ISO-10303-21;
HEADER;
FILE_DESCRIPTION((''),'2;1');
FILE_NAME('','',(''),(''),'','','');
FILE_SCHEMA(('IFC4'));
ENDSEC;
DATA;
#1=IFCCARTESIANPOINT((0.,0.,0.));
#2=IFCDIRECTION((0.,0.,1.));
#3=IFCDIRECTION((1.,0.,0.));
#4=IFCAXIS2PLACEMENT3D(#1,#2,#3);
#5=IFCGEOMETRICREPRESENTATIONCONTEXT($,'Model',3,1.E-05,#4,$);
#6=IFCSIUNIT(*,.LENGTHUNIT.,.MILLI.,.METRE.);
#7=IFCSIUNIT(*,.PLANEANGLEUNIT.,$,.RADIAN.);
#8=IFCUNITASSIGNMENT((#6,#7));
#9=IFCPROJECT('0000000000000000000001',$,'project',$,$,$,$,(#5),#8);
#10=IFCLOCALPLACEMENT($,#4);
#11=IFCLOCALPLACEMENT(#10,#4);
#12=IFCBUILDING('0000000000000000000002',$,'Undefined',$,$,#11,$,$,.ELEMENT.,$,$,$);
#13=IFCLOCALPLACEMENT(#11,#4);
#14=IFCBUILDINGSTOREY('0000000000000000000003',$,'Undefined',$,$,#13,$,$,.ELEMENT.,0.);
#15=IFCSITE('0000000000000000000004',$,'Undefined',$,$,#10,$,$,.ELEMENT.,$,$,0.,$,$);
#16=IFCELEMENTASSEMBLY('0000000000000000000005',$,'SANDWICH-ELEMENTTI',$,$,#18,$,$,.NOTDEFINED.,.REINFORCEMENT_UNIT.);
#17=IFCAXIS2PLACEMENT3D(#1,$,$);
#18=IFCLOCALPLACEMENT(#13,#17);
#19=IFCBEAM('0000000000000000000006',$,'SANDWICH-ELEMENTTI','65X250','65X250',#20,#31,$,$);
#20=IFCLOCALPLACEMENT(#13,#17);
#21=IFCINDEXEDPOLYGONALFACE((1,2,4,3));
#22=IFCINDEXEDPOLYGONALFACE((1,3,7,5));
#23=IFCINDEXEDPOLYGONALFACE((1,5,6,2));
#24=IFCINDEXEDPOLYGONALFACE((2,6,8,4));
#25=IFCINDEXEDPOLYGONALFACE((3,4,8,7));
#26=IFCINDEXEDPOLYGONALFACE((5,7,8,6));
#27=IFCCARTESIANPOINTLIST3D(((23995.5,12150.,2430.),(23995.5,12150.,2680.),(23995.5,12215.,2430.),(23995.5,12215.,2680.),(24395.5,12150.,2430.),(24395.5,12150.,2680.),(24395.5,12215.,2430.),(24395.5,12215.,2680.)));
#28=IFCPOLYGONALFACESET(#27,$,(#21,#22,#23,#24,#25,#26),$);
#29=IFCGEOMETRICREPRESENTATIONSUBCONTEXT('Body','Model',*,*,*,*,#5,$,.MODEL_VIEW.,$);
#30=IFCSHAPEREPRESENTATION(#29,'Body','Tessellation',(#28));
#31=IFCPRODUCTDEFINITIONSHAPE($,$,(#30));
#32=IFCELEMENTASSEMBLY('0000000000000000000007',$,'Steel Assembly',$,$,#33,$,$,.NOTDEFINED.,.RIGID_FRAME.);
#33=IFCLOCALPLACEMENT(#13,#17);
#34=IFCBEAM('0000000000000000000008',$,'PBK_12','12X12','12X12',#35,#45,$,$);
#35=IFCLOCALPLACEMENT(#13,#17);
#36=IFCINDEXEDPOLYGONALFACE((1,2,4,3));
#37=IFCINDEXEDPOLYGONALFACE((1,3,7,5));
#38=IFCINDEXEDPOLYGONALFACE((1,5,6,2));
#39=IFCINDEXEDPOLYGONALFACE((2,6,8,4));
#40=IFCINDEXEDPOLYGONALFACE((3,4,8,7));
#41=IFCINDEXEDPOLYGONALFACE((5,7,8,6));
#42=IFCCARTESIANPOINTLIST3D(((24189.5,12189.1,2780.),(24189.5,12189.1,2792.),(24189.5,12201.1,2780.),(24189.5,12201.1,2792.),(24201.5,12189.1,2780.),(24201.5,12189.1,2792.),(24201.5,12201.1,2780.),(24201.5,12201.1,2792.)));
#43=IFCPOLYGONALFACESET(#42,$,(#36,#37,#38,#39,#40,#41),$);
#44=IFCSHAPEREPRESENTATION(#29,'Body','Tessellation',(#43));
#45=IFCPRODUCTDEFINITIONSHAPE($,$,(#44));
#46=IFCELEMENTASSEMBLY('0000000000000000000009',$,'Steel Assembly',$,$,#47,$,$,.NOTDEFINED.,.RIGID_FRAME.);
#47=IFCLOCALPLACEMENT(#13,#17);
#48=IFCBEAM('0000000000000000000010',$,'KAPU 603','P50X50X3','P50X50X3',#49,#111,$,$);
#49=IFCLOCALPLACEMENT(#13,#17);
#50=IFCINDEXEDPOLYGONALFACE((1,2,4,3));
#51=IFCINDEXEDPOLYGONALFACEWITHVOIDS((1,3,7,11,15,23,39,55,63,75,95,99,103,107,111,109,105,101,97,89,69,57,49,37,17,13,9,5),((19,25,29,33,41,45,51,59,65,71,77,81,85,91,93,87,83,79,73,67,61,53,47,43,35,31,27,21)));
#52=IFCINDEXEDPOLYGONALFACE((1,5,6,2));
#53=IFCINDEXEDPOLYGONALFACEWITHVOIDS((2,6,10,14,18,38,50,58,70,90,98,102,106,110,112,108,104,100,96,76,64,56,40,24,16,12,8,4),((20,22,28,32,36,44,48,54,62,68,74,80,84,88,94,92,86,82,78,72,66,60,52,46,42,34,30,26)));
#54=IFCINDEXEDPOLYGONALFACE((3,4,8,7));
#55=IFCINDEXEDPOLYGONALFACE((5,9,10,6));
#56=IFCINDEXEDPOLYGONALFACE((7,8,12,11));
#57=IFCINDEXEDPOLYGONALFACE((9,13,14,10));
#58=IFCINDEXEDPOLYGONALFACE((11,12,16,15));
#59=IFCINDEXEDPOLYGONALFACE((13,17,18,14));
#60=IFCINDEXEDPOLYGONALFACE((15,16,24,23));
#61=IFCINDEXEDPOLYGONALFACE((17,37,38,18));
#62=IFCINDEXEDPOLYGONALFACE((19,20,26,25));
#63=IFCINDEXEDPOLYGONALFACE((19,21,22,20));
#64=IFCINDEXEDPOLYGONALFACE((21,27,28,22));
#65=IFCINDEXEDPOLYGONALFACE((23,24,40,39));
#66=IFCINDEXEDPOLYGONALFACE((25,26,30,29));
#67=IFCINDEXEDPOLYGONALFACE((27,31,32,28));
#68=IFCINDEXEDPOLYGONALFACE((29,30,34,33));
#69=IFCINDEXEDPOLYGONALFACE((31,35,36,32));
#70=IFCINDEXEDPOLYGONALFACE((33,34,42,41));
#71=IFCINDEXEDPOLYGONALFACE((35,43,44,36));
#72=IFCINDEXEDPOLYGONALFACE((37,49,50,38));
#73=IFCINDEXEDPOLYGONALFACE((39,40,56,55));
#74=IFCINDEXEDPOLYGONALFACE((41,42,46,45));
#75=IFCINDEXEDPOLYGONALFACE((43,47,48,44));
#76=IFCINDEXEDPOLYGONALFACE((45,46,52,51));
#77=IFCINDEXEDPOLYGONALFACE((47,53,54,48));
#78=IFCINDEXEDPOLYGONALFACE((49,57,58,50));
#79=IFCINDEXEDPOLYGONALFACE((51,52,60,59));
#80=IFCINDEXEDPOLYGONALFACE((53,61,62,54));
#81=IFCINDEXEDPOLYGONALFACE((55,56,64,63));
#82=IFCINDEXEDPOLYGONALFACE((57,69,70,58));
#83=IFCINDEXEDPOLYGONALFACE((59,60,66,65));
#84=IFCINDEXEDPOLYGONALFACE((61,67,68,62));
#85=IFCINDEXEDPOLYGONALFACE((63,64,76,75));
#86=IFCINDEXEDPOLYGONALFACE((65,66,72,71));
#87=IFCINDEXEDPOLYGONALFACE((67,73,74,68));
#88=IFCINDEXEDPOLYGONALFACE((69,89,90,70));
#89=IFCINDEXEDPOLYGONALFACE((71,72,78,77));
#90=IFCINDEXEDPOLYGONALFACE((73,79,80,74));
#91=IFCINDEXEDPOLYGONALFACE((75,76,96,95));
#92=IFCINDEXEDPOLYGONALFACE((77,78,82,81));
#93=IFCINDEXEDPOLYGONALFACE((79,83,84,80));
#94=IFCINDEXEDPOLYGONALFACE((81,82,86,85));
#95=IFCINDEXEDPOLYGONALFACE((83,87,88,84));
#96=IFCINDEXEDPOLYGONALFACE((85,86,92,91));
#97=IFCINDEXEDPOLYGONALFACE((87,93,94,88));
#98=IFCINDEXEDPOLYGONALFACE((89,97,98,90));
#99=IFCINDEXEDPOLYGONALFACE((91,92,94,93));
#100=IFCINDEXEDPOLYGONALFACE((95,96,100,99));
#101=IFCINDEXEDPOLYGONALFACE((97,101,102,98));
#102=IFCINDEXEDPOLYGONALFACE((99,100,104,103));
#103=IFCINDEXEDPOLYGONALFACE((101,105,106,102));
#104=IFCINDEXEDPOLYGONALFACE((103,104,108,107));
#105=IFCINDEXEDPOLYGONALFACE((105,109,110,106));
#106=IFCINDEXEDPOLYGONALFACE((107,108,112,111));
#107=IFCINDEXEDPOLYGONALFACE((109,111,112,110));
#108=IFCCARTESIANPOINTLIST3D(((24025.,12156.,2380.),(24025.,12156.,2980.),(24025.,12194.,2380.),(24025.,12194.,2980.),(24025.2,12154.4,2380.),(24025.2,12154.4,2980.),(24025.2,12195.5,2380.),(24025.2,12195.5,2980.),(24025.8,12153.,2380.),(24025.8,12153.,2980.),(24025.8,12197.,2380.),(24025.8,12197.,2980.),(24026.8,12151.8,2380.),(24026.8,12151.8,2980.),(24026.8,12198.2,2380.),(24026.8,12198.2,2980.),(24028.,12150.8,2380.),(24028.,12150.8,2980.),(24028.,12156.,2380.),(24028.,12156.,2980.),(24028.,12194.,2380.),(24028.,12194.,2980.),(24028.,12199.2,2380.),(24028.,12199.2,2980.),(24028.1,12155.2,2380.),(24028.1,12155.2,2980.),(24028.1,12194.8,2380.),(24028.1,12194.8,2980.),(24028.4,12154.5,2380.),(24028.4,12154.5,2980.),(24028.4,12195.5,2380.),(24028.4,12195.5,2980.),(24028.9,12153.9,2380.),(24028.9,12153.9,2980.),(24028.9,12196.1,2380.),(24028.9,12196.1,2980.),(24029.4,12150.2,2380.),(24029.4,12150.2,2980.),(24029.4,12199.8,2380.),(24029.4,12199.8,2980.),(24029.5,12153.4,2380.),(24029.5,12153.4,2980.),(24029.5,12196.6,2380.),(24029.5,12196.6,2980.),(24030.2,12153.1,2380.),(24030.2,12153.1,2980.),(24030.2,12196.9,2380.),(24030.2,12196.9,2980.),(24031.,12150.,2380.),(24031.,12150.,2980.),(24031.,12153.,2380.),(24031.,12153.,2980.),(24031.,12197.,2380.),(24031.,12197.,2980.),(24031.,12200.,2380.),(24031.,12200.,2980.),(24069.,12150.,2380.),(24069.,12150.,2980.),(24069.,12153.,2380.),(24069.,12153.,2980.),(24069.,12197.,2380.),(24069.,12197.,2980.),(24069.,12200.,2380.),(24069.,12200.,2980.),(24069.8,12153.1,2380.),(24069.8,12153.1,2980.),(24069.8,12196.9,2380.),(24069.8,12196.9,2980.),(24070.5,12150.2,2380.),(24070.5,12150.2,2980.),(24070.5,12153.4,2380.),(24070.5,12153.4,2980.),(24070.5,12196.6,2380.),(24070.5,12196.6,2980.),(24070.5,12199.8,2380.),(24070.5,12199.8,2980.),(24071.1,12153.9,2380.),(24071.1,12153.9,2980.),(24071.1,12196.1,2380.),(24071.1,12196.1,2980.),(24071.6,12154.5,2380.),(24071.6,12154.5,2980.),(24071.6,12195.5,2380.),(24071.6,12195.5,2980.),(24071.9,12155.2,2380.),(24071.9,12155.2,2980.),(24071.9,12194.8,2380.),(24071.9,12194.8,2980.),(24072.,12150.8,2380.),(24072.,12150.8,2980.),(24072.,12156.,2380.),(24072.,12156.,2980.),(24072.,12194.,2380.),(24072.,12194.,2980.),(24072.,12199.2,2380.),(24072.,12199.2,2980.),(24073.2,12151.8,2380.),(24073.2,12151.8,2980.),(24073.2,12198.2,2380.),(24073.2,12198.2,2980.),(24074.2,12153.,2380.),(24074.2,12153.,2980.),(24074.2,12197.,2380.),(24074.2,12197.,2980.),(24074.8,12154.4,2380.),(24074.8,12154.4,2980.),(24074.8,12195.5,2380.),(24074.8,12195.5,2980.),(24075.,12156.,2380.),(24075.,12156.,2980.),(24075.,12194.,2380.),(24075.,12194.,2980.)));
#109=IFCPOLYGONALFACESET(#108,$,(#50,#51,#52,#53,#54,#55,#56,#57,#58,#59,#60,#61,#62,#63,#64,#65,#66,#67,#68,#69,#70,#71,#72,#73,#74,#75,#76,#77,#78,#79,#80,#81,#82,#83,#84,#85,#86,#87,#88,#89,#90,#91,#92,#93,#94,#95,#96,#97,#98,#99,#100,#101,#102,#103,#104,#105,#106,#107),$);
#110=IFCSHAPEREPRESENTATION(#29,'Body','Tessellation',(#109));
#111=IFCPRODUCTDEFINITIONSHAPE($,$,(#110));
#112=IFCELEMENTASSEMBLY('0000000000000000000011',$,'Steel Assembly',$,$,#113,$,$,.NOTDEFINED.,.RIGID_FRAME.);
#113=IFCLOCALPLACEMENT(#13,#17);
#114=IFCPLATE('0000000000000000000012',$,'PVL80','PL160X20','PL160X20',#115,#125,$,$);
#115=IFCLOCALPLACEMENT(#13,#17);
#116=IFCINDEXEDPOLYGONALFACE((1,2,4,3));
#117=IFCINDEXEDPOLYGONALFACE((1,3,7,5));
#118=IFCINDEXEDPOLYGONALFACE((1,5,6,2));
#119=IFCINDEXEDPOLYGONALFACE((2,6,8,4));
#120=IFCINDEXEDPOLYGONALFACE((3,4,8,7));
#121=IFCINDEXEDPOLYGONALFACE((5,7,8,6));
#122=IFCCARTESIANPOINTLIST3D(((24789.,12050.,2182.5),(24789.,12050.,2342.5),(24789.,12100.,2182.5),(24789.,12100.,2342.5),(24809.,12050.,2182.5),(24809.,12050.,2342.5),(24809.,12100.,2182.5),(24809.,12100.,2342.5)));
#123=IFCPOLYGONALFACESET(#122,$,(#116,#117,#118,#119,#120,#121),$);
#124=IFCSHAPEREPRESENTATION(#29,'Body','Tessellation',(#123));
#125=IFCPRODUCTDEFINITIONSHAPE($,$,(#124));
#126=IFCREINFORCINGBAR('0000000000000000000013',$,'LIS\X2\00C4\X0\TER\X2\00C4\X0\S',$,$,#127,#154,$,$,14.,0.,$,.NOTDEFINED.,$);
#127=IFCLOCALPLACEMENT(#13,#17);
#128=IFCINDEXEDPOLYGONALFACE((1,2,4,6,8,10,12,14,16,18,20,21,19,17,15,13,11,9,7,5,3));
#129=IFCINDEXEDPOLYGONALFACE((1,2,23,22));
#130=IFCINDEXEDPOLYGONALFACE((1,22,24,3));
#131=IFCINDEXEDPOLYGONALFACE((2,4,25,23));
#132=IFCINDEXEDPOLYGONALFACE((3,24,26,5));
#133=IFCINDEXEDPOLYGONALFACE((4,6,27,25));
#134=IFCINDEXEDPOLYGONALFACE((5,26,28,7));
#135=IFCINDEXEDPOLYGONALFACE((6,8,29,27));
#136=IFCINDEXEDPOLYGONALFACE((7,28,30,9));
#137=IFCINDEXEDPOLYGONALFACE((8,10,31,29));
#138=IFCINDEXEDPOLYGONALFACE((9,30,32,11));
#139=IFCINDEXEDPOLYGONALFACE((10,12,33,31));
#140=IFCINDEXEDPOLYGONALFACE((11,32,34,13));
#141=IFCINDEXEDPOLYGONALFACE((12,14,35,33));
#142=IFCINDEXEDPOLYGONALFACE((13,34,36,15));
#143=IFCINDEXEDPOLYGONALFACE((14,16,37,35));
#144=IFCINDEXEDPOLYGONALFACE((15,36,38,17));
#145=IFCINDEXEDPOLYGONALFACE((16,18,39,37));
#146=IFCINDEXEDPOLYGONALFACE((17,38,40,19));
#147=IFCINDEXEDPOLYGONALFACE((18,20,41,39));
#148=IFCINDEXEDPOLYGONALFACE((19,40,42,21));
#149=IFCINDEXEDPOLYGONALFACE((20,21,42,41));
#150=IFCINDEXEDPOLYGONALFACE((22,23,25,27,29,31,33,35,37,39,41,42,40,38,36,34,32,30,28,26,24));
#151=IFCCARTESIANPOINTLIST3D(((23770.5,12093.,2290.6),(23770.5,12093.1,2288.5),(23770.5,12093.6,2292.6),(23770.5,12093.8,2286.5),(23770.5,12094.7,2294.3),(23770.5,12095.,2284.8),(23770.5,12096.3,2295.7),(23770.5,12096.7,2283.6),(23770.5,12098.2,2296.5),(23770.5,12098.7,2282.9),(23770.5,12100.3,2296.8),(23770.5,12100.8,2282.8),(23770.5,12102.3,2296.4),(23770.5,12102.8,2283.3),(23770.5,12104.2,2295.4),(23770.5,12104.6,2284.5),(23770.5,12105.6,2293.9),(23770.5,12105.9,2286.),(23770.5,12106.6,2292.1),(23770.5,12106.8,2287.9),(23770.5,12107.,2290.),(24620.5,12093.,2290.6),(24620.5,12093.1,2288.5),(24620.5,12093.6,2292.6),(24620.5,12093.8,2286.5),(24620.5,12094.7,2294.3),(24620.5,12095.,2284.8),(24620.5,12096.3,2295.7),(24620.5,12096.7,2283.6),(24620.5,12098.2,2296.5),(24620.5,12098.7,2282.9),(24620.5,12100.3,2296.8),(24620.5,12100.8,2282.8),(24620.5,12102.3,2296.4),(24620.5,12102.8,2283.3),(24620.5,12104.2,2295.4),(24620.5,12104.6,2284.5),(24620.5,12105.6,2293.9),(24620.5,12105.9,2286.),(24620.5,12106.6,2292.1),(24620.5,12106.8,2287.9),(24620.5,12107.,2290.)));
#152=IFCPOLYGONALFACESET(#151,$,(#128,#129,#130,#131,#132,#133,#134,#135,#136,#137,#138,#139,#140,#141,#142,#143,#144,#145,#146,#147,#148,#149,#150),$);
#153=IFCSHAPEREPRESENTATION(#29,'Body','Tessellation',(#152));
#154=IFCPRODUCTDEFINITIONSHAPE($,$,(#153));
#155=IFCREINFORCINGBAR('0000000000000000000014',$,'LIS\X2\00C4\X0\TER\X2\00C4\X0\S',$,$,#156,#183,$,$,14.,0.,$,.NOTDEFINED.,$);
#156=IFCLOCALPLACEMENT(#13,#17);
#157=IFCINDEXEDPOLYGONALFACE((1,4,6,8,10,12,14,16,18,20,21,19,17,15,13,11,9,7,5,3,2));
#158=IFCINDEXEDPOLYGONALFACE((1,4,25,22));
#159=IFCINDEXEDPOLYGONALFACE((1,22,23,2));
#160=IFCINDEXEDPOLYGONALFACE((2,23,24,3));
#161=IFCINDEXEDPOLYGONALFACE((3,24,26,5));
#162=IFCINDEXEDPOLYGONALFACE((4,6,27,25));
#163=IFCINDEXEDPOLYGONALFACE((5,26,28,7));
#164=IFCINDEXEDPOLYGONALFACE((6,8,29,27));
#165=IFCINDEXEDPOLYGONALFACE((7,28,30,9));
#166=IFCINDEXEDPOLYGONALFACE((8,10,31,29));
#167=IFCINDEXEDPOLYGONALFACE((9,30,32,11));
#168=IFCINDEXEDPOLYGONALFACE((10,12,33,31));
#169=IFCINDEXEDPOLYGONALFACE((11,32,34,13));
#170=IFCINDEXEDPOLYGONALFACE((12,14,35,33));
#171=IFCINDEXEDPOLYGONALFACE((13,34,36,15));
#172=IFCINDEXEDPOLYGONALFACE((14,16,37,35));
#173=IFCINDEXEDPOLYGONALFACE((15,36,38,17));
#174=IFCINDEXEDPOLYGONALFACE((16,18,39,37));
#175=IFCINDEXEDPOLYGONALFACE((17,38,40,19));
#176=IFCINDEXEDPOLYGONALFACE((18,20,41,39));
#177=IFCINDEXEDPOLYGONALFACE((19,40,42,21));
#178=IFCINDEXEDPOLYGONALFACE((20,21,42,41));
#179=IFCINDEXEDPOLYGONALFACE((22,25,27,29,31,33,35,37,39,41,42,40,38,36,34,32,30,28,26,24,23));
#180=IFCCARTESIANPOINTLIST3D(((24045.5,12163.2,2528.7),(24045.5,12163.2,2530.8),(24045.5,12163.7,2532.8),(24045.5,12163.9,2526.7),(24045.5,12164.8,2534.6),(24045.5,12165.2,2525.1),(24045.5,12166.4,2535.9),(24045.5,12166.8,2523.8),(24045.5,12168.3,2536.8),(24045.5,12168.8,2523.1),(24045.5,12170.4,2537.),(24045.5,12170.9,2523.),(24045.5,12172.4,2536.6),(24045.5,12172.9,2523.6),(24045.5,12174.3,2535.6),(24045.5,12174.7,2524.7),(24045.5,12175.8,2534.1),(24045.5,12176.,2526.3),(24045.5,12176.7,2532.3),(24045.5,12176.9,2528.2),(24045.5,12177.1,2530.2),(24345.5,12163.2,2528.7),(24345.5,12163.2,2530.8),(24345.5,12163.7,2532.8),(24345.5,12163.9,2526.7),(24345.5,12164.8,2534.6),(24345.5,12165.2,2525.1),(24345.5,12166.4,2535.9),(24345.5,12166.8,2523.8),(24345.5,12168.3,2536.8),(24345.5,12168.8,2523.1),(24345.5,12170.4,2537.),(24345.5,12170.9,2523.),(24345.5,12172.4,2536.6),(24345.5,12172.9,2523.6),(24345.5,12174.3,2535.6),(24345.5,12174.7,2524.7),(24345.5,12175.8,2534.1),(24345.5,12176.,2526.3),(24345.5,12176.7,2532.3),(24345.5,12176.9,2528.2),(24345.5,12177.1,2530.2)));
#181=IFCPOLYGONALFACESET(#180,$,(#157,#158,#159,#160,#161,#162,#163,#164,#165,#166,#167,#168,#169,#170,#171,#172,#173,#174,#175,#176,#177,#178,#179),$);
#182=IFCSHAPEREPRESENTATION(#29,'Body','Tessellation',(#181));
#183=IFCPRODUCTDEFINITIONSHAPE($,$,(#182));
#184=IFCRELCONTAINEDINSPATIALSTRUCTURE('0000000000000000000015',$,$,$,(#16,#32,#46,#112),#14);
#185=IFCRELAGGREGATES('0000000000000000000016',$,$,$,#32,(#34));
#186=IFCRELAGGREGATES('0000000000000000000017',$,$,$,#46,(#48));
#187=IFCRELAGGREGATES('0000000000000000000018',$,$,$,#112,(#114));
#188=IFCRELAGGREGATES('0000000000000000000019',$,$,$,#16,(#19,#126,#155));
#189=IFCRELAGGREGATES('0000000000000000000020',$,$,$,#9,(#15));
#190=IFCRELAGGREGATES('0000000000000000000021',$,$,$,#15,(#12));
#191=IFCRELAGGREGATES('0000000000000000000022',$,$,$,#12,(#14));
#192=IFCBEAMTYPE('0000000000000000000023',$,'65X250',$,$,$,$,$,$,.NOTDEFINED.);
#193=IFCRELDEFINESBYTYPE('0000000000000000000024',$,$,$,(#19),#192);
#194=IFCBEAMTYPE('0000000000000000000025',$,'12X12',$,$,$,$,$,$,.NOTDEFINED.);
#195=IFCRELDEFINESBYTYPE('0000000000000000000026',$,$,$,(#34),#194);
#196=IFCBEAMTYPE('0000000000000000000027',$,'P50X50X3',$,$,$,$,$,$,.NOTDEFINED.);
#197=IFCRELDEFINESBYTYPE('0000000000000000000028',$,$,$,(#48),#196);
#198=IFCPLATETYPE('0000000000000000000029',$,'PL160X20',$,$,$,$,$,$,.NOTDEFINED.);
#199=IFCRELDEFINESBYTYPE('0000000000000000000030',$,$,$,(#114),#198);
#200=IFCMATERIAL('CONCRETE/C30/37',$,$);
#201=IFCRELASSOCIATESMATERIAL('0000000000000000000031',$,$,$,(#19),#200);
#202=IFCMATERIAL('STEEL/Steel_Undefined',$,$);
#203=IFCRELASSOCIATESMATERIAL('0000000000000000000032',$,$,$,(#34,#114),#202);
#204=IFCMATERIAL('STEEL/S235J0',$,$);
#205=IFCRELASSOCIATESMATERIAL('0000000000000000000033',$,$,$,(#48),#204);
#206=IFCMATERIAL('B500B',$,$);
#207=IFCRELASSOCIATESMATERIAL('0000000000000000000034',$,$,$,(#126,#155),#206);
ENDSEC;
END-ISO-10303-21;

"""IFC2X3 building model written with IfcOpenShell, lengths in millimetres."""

from ifc_helpers import new_model, entity, si_unit, frame, origin_with_axes, origin_2d_with_axis, place, context, subcontext, project, spatial, polyline, rectangle, hollow_rectangle, outline, extrude, source, transform, mapped, material, type_object, element, aggregate, save


model = new_model("IFC2X3")

# Units and contexts
model_context = context("Model", 3, precision=1e-05, world=origin_with_axes())
body_context = subcontext(model_context, "Body", "Model", "MODEL_VIEW")
ifc_project = project(units=[si_unit("LENGTHUNIT", "METRE", prefix="MILLI"), si_unit("PLANEANGLEUNIT", "RADIAN")], contexts=[model_context])

# Site, building, storey
site_placement = place(None, origin_with_axes())
site = spatial("IfcSite", under=ifc_project, at=site_placement, Name="Undefined", CompositionType="ELEMENT", RefElevation=0.0)
building_placement = place(site_placement, origin_with_axes())
building = spatial("IfcBuilding", under=site, at=building_placement, Name="Undefined", CompositionType="ELEMENT")
storey_placement = place(building_placement, origin_with_axes())
storey = spatial("IfcBuildingStorey", under=building, at=storey_placement, Name="Undefined", CompositionType="ELEMENT", Elevation=0.0)

# Element assemblies, beams
assembly_1_placement = place(storey_placement, origin_with_axes())
assembly_1 = element("IfcElementAssembly", 1, at=assembly_1_placement, inside=storey, Name="SANDWICH-ELEMENTTI", AssemblyPlace="NOTDEFINED", PredefinedType="REINFORCEMENT_UNIT")
ifc_material_1 = material(Name="CONCRETE/C30/37")
beam_type_1 = type_object("IfcBeamType", Name="65X250", PredefinedType="NOTDEFINED")
beam_1_placement = place(assembly_1_placement, frame((23995.5, 12182.5, 2555.0), z_axis=(0.0, -1.0, 0.0), x_axis=(1.0, 0.0, 0.0)))
beam_1 = element("IfcBeam", 2, at=beam_1_placement, type_object=beam_type_1, material=ifc_material_1, Name="SANDWICH-ELEMENTTI", Description="65X250", ObjectType="65X250", context=body_context, shape_type="SweptSolid", body=[
    extrude(rectangle(XDim=250.0, YDim=65.0, at=origin_2d_with_axis()), frame((400.0, 0.0, 0.0), z_axis=(-1.0, 0.0, 0.0), x_axis=(0.0, -1.0, 0.0)), (0.0, 0.0, 1.0), 400.0),
])
assembly_2_placement = place(storey_placement, origin_with_axes())
assembly_2 = element("IfcElementAssembly", 3, at=assembly_2_placement, inside=storey, Name="Steel Assembly", AssemblyPlace="NOTDEFINED", PredefinedType="RIGID_FRAME")
ifc_material_2 = material(Name="STEEL/Steel_Undefined")
beam_type_2 = type_object("IfcBeamType", Name="12X12", PredefinedType="NOTDEFINED")
beam_2_placement = place(assembly_2_placement, frame((24201.5, 12195.1, 2786.0), z_axis=(0.0, 0.0, 1.0), x_axis=(-1.0, 0.0, 0.0)))
beam_2 = element("IfcBeam", 4, at=beam_2_placement, type_object=beam_type_2, material=ifc_material_2, Name="PBK_12", Description="12X12", ObjectType="12X12", context=body_context, shape_type="SweptSolid", body=[
    extrude(rectangle(XDim=12.0, YDim=12.0, at=origin_2d_with_axis()), frame((12.0, 0.0, 0.0), z_axis=(-1.0, 0.0, 0.0), x_axis=(0.0, -1.0, 0.0)), (0.0, 0.0, 1.0), 12.0),
])
aggregate(assembly_2, [beam_2])
assembly_3_placement = place(storey_placement, origin_with_axes())
assembly_3 = element("IfcElementAssembly", 5, at=assembly_3_placement, inside=storey, Name="Steel Assembly", AssemblyPlace="NOTDEFINED", PredefinedType="RIGID_FRAME")
ifc_material_3 = material(Name="STEEL/S235J0")
beam_type_3 = type_object("IfcBeamType", Name="P50X50X3", PredefinedType="NOTDEFINED")
beam_3_placement = place(assembly_3_placement, frame((24050.0, 12175.0, 2980.0), z_axis=(1.0, 0.0, 0.0), x_axis=(0.0, 0.0, -1.0)))
beam_3 = element("IfcBeam", 6, at=beam_3_placement, type_object=beam_type_3, material=ifc_material_3, Name="KAPU 603", Description="P50X50X3", ObjectType="P50X50X3", context=body_context, shape_type="SweptSolid", body=[
    extrude(hollow_rectangle(XDim=50.0, YDim=50.0, WallThickness=3.0, InnerFilletRadius=3.0, OuterFilletRadius=6.0, at=origin_2d_with_axis()), frame((600.0, 0.0, 0.0), z_axis=(-1.0, 0.0, 0.0), x_axis=(0.0, -1.0, 0.0)), (0.0, 0.0, 1.0), 600.0),
])
aggregate(assembly_3, [beam_3])

# Element assembly, plate
assembly_4_placement = place(storey_placement, origin_with_axes())
assembly_4 = element("IfcElementAssembly", 7, at=assembly_4_placement, inside=storey, Name="Steel Assembly", AssemblyPlace="NOTDEFINED", PredefinedType="RIGID_FRAME")
plate_type = type_object("IfcPlateType", Name="PL160X20", PredefinedType="NOTDEFINED")
plate_placement = place(assembly_4_placement, frame((24809.0, 12100.0, 2262.5), z_axis=(0.0, 0.0, -1.0), x_axis=(0.0, -1.0, 0.0)))
plate = element("IfcPlate", 8, at=plate_placement, type_object=plate_type, material=ifc_material_2, Name="PVL80", Description="PL160X20", ObjectType="PL160X20", context=body_context, shape_type="SweptSolid", body=[
    extrude(outline(polyline([(0.0, 0.0), (50.0, 0.0), (50.0, 20.0), (0.0, 20.0), (0.0, 0.0)])), frame((0.0, 0.0, -80.0), z_axis=(0.0, 0.0, 1.0), x_axis=(1.0, 0.0, 0.0)), (0.0, 0.0, 1.0), 160.0),
])

aggregate(assembly_4, [plate])

# Reinforcing bars
ifc_material_4 = material(Name="B500B")
shared_shape_1 = source(origin_with_axes(), body_context, "Body", "AdvancedSweptSolid", [
    entity("IfcSweptDiskSolid", entity("IfcTrimmedCurve", entity("IfcLine", entity("IfcCartesianPoint", [0.0, 0.0, 0.0]), entity("IfcVector", entity("IfcDirection", [1.0, 0.0, 0.0]), 1.0)), [entity("IfcParameterValue", 0.0)], [entity("IfcParameterValue", 850.0)], True, "PARAMETER"), 7.0, None, 0.0, 850.0),
])
reinforcing_bar_1_placement = place(assembly_1_placement, frame((23770.5, 12100.0, 2289.8), z_axis=(0.0, 0.110296, -0.993899), x_axis=(1.0, 0.0, 0.0)))
reinforcing_bar_1 = element("IfcReinforcingBar", 9, at=reinforcing_bar_1_placement, material=ifc_material_4, Name="LISÄTERÄS", BarRole="NOTDEFINED", CrossSectionArea=0.0, NominalDiameter=14.0, context=body_context, shape_type="MappedRepresentation", body=[
    mapped(shared_shape_1, transform((0.0, 0.0, 0.0))),
])
shared_shape_2 = source(origin_with_axes(), body_context, "Body", "AdvancedSweptSolid", [
    entity("IfcSweptDiskSolid", entity("IfcTrimmedCurve", entity("IfcLine", entity("IfcCartesianPoint", [0.0, 0.0, 0.0]), entity("IfcVector", entity("IfcDirection", [1.0, 0.0, 0.0]), 1.0)), [entity("IfcParameterValue", 0.0)], [entity("IfcParameterValue", 300.0)], True, "PARAMETER"), 7.0, None, 0.0, 300.0),
])
reinforcing_bar_2_placement = place(assembly_1_placement, frame((24045.5, 12170.1, 2530.0), z_axis=(0.0, 0.110296, -0.993899), x_axis=(1.0, 0.0, 0.0)))
reinforcing_bar_2 = element("IfcReinforcingBar", 10, at=reinforcing_bar_2_placement, material=ifc_material_4, Name="LISÄTERÄS", BarRole="NOTDEFINED", CrossSectionArea=0.0, NominalDiameter=14.0, context=body_context, shape_type="MappedRepresentation", body=[
    mapped(shared_shape_2, transform((0.0, 0.0, 0.0))),
])
aggregate(assembly_1, [beam_1, reinforcing_bar_1, reinforcing_bar_2])

save(model, "model.ifc")
